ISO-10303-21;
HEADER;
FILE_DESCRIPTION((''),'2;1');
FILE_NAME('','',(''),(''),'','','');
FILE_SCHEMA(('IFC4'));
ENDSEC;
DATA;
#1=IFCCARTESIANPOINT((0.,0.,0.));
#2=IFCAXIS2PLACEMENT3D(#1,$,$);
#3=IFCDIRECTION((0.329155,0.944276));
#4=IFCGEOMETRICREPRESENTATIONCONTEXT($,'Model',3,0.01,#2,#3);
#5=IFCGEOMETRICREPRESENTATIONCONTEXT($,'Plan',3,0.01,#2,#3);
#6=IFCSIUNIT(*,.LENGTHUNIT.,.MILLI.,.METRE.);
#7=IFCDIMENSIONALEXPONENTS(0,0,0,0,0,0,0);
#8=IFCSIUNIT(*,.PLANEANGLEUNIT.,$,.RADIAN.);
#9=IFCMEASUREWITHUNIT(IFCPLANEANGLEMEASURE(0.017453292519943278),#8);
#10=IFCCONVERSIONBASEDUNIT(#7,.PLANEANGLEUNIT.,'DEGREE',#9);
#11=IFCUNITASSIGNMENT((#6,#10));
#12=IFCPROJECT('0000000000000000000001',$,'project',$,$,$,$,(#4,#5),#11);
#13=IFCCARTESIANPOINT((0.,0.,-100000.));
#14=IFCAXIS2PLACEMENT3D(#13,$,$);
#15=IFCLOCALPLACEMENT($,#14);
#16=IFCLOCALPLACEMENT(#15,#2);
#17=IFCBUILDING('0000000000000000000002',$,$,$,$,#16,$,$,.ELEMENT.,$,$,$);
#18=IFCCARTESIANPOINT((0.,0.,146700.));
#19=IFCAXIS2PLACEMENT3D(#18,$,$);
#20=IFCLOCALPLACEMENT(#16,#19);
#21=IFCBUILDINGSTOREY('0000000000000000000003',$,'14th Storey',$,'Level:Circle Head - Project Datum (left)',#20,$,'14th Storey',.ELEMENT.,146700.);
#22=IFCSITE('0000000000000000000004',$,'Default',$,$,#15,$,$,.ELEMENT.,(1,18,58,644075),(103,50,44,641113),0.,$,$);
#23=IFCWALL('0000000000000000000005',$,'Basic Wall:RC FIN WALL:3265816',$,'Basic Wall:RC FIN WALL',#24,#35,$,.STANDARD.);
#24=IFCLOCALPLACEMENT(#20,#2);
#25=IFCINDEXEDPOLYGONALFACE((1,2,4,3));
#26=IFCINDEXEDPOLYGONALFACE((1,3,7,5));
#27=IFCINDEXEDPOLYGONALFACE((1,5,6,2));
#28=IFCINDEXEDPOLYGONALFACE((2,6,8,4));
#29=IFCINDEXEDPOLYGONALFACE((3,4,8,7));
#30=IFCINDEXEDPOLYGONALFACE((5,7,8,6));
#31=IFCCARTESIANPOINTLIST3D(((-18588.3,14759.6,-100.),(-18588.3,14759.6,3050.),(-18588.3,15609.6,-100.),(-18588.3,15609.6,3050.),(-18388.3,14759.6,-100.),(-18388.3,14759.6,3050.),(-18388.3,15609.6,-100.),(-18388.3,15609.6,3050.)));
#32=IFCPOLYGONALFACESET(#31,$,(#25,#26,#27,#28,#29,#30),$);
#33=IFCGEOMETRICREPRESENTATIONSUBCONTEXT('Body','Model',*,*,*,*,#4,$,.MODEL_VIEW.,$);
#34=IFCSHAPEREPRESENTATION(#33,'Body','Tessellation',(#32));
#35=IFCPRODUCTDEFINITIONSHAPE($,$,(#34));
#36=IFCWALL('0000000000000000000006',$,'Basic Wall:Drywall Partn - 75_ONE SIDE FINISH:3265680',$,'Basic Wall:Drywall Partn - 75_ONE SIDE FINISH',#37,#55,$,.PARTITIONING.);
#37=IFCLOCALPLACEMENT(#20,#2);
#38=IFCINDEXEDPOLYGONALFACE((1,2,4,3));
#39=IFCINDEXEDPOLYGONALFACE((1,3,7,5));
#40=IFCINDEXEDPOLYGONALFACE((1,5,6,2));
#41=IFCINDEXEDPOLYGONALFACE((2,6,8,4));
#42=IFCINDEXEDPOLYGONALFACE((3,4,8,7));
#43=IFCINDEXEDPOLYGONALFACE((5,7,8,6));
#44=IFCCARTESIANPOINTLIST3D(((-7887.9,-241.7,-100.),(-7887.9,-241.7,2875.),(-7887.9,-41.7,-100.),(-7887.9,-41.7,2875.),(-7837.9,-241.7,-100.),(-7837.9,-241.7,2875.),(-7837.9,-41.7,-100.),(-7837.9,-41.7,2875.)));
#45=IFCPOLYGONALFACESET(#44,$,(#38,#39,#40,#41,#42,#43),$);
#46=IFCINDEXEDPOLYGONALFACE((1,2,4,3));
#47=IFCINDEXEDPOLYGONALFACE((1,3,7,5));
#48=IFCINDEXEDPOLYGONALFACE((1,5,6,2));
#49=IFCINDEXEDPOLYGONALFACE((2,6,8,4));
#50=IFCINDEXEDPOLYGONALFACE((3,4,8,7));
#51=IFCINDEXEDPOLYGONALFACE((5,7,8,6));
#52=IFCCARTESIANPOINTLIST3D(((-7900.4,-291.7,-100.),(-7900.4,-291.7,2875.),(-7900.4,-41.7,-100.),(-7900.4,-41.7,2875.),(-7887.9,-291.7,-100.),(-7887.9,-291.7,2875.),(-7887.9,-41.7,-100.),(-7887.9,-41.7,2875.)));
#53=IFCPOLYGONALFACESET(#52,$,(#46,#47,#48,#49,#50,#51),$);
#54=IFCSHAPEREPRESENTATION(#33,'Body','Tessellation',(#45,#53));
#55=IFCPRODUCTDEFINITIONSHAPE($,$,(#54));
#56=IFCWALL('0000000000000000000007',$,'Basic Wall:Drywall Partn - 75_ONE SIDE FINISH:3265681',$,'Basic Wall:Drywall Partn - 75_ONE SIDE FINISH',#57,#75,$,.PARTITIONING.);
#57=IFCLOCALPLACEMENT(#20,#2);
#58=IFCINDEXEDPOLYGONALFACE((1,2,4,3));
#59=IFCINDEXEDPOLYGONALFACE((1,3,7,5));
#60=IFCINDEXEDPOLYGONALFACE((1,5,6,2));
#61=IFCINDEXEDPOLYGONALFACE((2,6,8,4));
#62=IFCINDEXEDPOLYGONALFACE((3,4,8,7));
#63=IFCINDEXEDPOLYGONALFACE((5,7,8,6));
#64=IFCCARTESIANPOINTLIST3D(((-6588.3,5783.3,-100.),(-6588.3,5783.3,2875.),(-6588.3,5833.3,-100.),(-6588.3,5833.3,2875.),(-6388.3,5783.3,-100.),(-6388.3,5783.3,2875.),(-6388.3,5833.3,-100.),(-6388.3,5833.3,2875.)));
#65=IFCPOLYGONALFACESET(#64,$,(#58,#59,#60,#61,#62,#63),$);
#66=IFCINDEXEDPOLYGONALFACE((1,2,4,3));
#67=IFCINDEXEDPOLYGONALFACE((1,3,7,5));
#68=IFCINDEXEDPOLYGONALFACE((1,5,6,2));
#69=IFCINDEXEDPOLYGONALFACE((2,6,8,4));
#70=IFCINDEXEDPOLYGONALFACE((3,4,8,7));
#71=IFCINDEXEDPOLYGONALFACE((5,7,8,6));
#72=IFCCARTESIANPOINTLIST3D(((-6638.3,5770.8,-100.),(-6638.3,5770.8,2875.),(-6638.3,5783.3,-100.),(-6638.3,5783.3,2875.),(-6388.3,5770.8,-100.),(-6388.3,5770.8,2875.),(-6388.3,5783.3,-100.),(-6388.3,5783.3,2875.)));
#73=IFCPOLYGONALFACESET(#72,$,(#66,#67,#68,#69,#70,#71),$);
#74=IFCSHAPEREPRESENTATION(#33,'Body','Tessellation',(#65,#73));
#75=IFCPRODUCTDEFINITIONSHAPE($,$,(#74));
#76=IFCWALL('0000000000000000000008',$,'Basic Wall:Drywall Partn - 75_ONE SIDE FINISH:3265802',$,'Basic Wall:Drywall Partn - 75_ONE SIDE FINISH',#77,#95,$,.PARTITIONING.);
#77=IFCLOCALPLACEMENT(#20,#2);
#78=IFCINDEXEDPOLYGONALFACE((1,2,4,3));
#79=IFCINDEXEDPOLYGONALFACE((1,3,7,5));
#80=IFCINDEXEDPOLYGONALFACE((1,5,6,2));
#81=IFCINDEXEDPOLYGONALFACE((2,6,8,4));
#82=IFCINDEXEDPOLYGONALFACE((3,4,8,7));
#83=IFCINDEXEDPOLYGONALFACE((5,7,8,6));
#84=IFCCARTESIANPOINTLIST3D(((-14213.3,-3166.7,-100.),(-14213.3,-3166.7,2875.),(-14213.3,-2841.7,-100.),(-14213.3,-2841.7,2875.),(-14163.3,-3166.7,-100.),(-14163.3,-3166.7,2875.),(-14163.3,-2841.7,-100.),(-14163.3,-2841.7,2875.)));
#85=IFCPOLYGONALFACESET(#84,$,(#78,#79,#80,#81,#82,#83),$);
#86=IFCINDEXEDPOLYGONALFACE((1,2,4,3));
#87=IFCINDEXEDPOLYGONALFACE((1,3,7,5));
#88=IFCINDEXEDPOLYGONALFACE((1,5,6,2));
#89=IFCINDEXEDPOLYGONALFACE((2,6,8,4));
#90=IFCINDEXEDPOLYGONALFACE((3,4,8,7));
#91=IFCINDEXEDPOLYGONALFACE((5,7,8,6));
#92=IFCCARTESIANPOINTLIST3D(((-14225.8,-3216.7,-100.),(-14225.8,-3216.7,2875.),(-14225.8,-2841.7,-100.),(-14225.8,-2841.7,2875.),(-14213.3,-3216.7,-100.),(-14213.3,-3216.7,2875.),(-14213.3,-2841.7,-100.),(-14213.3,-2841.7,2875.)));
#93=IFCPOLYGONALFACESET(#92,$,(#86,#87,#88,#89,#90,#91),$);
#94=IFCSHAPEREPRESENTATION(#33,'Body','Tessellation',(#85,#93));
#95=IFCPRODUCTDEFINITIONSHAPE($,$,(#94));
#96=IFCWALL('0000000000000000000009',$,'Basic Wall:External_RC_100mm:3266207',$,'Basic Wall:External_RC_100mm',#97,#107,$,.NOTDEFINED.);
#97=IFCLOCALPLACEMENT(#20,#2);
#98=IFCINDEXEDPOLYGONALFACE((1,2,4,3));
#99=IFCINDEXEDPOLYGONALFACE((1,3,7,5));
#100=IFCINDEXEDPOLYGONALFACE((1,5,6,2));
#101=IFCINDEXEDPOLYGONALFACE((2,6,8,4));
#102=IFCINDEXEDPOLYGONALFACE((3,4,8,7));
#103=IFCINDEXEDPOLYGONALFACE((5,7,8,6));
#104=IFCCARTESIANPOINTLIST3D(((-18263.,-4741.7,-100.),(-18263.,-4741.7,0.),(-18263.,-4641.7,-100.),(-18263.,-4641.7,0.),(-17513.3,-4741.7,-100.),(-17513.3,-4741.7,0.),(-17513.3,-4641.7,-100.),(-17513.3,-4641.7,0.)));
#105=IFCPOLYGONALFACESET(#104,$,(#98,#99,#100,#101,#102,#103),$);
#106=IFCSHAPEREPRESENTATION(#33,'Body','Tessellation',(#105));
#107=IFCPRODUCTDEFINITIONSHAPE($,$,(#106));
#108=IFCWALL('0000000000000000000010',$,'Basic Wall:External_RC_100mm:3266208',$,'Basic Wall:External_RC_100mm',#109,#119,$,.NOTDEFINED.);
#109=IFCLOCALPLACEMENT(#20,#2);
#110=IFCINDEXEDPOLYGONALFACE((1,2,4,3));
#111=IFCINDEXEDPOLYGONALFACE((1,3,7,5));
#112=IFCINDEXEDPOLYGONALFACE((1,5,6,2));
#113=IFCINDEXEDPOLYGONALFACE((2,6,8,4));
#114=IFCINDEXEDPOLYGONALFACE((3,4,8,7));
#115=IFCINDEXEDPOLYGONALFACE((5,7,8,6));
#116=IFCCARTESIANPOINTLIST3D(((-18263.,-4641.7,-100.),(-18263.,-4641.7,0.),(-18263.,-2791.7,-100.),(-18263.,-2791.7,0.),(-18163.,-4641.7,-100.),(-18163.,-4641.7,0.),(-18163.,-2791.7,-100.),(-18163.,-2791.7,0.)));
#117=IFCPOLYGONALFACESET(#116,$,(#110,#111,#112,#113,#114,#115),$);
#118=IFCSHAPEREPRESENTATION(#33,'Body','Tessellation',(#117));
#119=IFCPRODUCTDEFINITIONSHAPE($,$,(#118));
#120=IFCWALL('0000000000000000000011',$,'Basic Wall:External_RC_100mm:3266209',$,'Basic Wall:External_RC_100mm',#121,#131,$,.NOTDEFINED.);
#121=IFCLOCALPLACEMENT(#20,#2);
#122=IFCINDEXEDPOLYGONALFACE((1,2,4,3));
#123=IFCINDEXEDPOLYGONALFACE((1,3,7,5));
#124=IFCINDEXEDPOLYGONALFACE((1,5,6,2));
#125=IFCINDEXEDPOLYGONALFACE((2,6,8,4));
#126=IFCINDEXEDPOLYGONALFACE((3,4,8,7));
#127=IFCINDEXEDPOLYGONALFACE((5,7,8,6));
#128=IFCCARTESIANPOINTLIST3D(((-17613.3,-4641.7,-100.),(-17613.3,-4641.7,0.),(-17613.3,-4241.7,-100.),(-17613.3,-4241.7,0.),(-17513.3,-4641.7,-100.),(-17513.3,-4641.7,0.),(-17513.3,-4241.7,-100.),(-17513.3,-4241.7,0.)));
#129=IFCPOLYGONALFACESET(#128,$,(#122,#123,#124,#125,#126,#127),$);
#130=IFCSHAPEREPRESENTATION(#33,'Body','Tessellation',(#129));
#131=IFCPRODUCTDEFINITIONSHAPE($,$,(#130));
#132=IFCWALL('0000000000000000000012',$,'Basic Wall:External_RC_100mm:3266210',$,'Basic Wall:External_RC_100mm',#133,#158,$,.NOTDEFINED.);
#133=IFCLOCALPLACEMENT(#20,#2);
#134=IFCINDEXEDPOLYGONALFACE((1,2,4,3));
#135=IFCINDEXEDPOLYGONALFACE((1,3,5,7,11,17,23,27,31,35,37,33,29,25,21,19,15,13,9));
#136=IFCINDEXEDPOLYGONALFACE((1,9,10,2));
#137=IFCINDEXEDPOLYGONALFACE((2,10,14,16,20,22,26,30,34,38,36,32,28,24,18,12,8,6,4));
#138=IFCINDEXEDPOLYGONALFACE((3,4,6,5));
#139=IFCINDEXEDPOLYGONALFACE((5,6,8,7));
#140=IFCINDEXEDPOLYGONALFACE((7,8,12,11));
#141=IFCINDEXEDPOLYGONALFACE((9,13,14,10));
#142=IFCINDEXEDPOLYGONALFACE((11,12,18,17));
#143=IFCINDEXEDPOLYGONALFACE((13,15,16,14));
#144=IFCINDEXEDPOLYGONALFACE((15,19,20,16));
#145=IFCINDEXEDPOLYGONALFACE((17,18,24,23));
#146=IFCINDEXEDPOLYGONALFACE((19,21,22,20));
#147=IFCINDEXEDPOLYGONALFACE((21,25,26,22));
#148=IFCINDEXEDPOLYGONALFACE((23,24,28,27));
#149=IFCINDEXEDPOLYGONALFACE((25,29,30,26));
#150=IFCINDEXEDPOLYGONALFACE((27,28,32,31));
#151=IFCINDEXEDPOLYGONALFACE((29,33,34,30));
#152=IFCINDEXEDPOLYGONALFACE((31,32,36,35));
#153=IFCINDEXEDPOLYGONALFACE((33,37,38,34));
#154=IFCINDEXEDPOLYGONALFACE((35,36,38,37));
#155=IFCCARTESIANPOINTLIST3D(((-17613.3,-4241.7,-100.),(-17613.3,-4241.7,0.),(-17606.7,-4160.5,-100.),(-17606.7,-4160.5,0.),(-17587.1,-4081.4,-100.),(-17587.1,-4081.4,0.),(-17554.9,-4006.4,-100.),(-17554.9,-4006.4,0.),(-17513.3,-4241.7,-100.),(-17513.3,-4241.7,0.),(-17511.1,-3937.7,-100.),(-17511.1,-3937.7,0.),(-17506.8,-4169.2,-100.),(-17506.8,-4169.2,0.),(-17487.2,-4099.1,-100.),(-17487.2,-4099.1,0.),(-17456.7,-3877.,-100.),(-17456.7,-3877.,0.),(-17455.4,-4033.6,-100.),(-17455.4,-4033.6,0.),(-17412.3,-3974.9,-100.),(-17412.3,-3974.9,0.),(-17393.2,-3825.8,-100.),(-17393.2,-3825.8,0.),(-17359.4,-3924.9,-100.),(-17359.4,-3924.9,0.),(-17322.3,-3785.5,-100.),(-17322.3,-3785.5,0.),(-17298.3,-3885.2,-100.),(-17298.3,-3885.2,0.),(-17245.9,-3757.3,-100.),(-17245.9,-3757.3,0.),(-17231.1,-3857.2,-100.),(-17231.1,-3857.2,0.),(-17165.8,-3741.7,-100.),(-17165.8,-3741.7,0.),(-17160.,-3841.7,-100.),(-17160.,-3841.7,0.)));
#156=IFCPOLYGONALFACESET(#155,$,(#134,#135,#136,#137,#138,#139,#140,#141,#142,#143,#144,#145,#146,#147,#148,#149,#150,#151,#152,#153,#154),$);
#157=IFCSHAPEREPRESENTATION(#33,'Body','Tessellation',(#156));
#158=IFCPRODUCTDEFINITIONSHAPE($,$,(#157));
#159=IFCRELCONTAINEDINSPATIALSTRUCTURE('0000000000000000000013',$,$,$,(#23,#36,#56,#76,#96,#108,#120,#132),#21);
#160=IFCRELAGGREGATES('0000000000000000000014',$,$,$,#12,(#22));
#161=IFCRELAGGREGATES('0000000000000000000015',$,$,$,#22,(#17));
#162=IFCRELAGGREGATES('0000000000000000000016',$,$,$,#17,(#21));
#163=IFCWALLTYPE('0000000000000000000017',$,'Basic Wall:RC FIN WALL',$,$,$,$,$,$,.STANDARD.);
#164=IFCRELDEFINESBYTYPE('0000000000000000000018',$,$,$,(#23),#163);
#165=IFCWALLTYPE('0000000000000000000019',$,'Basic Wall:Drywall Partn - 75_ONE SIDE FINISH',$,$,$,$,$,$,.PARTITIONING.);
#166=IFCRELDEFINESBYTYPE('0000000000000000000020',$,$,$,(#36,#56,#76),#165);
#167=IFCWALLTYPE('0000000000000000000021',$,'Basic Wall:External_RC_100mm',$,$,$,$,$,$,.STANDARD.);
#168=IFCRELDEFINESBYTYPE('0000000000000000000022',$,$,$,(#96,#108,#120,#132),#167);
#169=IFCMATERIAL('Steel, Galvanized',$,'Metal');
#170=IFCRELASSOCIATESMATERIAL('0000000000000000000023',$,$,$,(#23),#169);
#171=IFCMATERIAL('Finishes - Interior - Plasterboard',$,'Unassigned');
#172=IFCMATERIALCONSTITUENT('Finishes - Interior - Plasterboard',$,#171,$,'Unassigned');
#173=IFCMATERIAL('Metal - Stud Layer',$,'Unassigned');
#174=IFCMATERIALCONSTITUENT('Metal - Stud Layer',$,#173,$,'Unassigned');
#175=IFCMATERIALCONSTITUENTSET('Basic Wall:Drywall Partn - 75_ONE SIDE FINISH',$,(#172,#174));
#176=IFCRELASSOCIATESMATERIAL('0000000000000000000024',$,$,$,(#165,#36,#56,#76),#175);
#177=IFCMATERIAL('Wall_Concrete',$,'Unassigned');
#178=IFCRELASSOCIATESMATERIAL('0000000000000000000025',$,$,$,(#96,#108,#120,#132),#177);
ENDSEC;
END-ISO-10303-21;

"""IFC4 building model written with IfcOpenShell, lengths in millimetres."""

from ifc_helpers import new_model, entity, si_unit, converted_unit, direction, frame, origin, place, context, subcontext, project, spatial, line, arc, indexed_curve, outline, extrude, material, constituent, constituent_set, type_object, element, save


model = new_model("IFC4")

# Units and contexts
model_context = context("Model", 3, precision=0.01, world=origin(), true_north=direction((0.329155, 0.944276)))
plan_context = context("Plan", 3, precision=0.01, world=origin(), true_north=direction((0.329155, 0.944276)))
body_context = subcontext(model_context, "Body", "Model", "MODEL_VIEW")
ifc_project = project(units=[si_unit("LENGTHUNIT", "METRE", prefix="MILLI"), converted_unit("PLANEANGLEUNIT", "DEGREE", entity("IfcPlaneAngleMeasure", 0.017453292519943278), si_unit("PLANEANGLEUNIT", "RADIAN"), dimensions=[0, 0, 0, 0, 0, 0, 0])], contexts=[model_context, plan_context])

# Site, building, storey
site_placement = place(None, frame((0.0, 0.0, -100000.0)))
site = spatial("IfcSite", under=ifc_project, at=site_placement, Name="Default", CompositionType="ELEMENT", RefLatitude=(1, 18, 58, 644075), RefLongitude=(103, 50, 44, 641113), RefElevation=0.0)
building_placement = place(site_placement, origin())
building = spatial("IfcBuilding", under=site, at=building_placement, CompositionType="ELEMENT")
storey_placement = place(building_placement, frame((0.0, 0.0, 146700.0)))
storey = spatial("IfcBuildingStorey", under=building, at=storey_placement, Name="14th Storey", ObjectType="Level:Circle Head - Project Datum (left)", LongName="14th Storey", CompositionType="ELEMENT", Elevation=146700.0)

# Walls
ifc_material_1 = material(Name="Wall_Concrete", Category="Unassigned")
ifc_material_2 = material(Name="Steel, Galvanized", Category="Metal")
wall_type_1 = type_object("IfcWallType", Name="Basic Wall:RC FIN WALL", PredefinedType="STANDARD")
wall_1_placement = place(storey_placement, frame((-18488.3, 14759.6, -100.0), z_axis=(0.0, 0.0, 1.0), x_axis=(0.0, 1.0, 0.0)))
element("IfcWall", 1, at=wall_1_placement, inside=storey, type_object=wall_type_1, material=ifc_material_2, Name="Basic Wall:RC FIN WALL:3265816", ObjectType="Basic Wall:RC FIN WALL", PredefinedType="STANDARD", context=body_context, shape_type="SweptSolid", body=[
    extrude(outline(indexed_curve([(850.0, 100.0), (0.0, 100.0), (0.0, -100.0), (850.0, -100.0), (850.0, 100.0)], self_intersect=False)), origin(), (0.0, 0.0, 1.0), 3150.0),
])
ifc_material_3 = material(Name="Finishes - Interior - Plasterboard", Category="Unassigned")
ifc_constituent_1 = constituent(ifc_material_3, Name="Finishes - Interior - Plasterboard", Category="Unassigned")
ifc_material_4 = material(Name="Metal - Stud Layer", Category="Unassigned")
ifc_constituent_2 = constituent(ifc_material_4, Name="Metal - Stud Layer", Category="Unassigned")
ifc_constituent_set = constituent_set(constituents=[ifc_constituent_1, ifc_constituent_2], Name="Basic Wall:Drywall Partn - 75_ONE SIDE FINISH")
wall_type_2 = type_object("IfcWallType", Name="Basic Wall:Drywall Partn - 75_ONE SIDE FINISH", PredefinedType="PARTITIONING", material=ifc_constituent_set)
wall_2_placement = place(storey_placement, frame((-7869.1, -241.7, -100.0), z_axis=(0.0, 0.0, 1.0), x_axis=(0.0, 1.0, 0.0)))
element("IfcWall", 2, at=wall_2_placement, inside=storey, type_object=wall_type_2, material=ifc_constituent_set, Name="Basic Wall:Drywall Partn - 75_ONE SIDE FINISH:3265680", ObjectType="Basic Wall:Drywall Partn - 75_ONE SIDE FINISH", PredefinedType="PARTITIONING", context=body_context, shape_type="SweptSolid", body=[
    extrude(outline(indexed_curve([(-25.0, -100.0), (25.0, -100.0), (25.0, 100.0), (-25.0, 100.0), (-25.0, -100.0)], self_intersect=False)), frame((100.0, -6.2, 0.0), z_axis=(0.0, 0.0, 1.0), x_axis=(0.0, 1.0, 0.0)), (0.0, 0.0, 1.0), 2975.0),
    extrude(outline(indexed_curve([(-6.3, -125.0), (6.2, -125.0), (6.3, 125.0), (-6.3, 125.0), (-6.3, -125.0)], self_intersect=False)), frame((75.0, 25.0, 0.0), z_axis=(0.0, 0.0, 1.0), x_axis=(0.0, -1.0, 0.0)), (0.0, 0.0, 1.0), 2975.0),
])
wall_3_placement = place(storey_placement, frame((-6388.3, 5802.0, -100.0), z_axis=(0.0, 0.0, 1.0), x_axis=(-1.0, 0.0, 0.0)))
element("IfcWall", 3, at=wall_3_placement, inside=storey, type_object=wall_type_2, material=ifc_constituent_set, Name="Basic Wall:Drywall Partn - 75_ONE SIDE FINISH:3265681", ObjectType="Basic Wall:Drywall Partn - 75_ONE SIDE FINISH", PredefinedType="PARTITIONING", context=body_context, shape_type="SweptSolid", body=[
    extrude(outline(indexed_curve([(-25.0, -100.0), (25.0, -100.0), (25.0, 100.0), (-25.0, 100.0), (-25.0, -100.0)], self_intersect=False)), frame((100.0, -6.2, 0.0), z_axis=(0.0, 0.0, 1.0), x_axis=(0.0, 1.0, 0.0)), (0.0, 0.0, 1.0), 2975.0),
    extrude(outline(indexed_curve([(-6.2, -125.0), (6.3, -125.0), (6.2, 125.0), (-6.3, 125.0), (-6.2, -125.0)], self_intersect=False)), frame((125.0, 25.0, 0.0), z_axis=(0.0, 0.0, 1.0), x_axis=(0.0, -1.0, 0.0)), (0.0, 0.0, 1.0), 2975.0),
])
wall_4_placement = place(storey_placement, frame((-14194.6, -2841.7, -100.0), z_axis=(0.0, 0.0, 1.0), x_axis=(0.0, -1.0, 0.0)))
element("IfcWall", 4, at=wall_4_placement, inside=storey, type_object=wall_type_2, material=ifc_constituent_set, Name="Basic Wall:Drywall Partn - 75_ONE SIDE FINISH:3265802", ObjectType="Basic Wall:Drywall Partn - 75_ONE SIDE FINISH", PredefinedType="PARTITIONING", context=body_context, shape_type="SweptSolid", body=[
    extrude(outline(indexed_curve([(-25.0, -162.5), (25.0, -162.5), (25.0, 162.5), (-25.0, 162.5), (-25.0, -162.5)], self_intersect=False)), frame((162.5, 6.2, 0.0), z_axis=(0.0, 0.0, 1.0), x_axis=(0.0, -1.0, 0.0)), (0.0, 0.0, 1.0), 2975.0),
    extrude(outline(indexed_curve([(-6.3, -187.5), (6.2, -187.5), (6.2, 187.5), (-6.3, 187.5), (-6.3, -187.5)], self_intersect=False)), frame((187.5, -25.0, 0.0), z_axis=(0.0, 0.0, 1.0), x_axis=(0.0, -1.0, 0.0)), (0.0, 0.0, 1.0), 2975.0),
])
wall_type_3 = type_object("IfcWallType", Name="Basic Wall:External_RC_100mm", PredefinedType="STANDARD")
wall_5_placement = place(storey_placement, frame((-18263.0, -4691.7, -100.0)))
element("IfcWall", 5, at=wall_5_placement, inside=storey, type_object=wall_type_3, material=ifc_material_1, Name="Basic Wall:External_RC_100mm:3266207", ObjectType="Basic Wall:External_RC_100mm", PredefinedType="NOTDEFINED", context=body_context, shape_type="SweptSolid", body=[
    extrude(outline(indexed_curve([(749.6, 50.0), (0.0, 50.0), (0.0, -50.0), (749.6, -50.0), (749.6, 50.0)], self_intersect=False)), origin(), (0.0, 0.0, 1.0), 100.0),
])
wall_6_placement = place(storey_placement, frame((-18213.0, -2791.7, -100.0), z_axis=(0.0, 0.0, 1.0), x_axis=(0.0, -1.0, 0.0)))
element("IfcWall", 6, at=wall_6_placement, inside=storey, type_object=wall_type_3, material=ifc_material_1, Name="Basic Wall:External_RC_100mm:3266208", ObjectType="Basic Wall:External_RC_100mm", PredefinedType="NOTDEFINED", context=body_context, shape_type="SweptSolid", body=[
    extrude(outline(indexed_curve([(1850.0, 50.0), (0.0, 50.0), (0.0, -50.0), (1850.0, -50.0), (1850.0, 50.0)], self_intersect=False)), origin(), (0.0, 0.0, 1.0), 100.0),
])
wall_7_placement = place(storey_placement, frame((-17563.3, -4641.7, -100.0), z_axis=(0.0, 0.0, 1.0), x_axis=(0.0, 1.0, 0.0)))
element("IfcWall", 7, at=wall_7_placement, inside=storey, type_object=wall_type_3, material=ifc_material_1, Name="Basic Wall:External_RC_100mm:3266209", ObjectType="Basic Wall:External_RC_100mm", PredefinedType="NOTDEFINED", context=body_context, shape_type="SweptSolid", body=[
    extrude(outline(indexed_curve([(400.0, 50.0), (0.0, 50.0), (0.0, -50.0), (400.0, -50.0), (400.0, 50.0)], self_intersect=False)), origin(), (0.0, 0.0, 1.0), 100.0),
])
wall_8_placement = place(storey_placement, frame((-17563.3, -4241.7, -100.0)))
element("IfcWall", 8, at=wall_8_placement, inside=storey, type_object=wall_type_3, material=ifc_material_1, Name="Basic Wall:External_RC_100mm:3266210", ObjectType="Basic Wall:External_RC_100mm", PredefinedType="NOTDEFINED", context=body_context, shape_type="SweptSolid", body=[
    extrude(outline(indexed_curve([(397.5, 500.0), (78.2, 335.5), (-50.0, 0.0), (50.0, 0.0), (151.0, 266.9), (403.4, 400.0)], segments=[arc(1, 2, 3), line(3, 4), arc(4, 5, 6), line(6, 1)], self_intersect=False)), origin(), (0.0, 0.0, 1.0), 100.0),
])

save(model, "model.ifc")
